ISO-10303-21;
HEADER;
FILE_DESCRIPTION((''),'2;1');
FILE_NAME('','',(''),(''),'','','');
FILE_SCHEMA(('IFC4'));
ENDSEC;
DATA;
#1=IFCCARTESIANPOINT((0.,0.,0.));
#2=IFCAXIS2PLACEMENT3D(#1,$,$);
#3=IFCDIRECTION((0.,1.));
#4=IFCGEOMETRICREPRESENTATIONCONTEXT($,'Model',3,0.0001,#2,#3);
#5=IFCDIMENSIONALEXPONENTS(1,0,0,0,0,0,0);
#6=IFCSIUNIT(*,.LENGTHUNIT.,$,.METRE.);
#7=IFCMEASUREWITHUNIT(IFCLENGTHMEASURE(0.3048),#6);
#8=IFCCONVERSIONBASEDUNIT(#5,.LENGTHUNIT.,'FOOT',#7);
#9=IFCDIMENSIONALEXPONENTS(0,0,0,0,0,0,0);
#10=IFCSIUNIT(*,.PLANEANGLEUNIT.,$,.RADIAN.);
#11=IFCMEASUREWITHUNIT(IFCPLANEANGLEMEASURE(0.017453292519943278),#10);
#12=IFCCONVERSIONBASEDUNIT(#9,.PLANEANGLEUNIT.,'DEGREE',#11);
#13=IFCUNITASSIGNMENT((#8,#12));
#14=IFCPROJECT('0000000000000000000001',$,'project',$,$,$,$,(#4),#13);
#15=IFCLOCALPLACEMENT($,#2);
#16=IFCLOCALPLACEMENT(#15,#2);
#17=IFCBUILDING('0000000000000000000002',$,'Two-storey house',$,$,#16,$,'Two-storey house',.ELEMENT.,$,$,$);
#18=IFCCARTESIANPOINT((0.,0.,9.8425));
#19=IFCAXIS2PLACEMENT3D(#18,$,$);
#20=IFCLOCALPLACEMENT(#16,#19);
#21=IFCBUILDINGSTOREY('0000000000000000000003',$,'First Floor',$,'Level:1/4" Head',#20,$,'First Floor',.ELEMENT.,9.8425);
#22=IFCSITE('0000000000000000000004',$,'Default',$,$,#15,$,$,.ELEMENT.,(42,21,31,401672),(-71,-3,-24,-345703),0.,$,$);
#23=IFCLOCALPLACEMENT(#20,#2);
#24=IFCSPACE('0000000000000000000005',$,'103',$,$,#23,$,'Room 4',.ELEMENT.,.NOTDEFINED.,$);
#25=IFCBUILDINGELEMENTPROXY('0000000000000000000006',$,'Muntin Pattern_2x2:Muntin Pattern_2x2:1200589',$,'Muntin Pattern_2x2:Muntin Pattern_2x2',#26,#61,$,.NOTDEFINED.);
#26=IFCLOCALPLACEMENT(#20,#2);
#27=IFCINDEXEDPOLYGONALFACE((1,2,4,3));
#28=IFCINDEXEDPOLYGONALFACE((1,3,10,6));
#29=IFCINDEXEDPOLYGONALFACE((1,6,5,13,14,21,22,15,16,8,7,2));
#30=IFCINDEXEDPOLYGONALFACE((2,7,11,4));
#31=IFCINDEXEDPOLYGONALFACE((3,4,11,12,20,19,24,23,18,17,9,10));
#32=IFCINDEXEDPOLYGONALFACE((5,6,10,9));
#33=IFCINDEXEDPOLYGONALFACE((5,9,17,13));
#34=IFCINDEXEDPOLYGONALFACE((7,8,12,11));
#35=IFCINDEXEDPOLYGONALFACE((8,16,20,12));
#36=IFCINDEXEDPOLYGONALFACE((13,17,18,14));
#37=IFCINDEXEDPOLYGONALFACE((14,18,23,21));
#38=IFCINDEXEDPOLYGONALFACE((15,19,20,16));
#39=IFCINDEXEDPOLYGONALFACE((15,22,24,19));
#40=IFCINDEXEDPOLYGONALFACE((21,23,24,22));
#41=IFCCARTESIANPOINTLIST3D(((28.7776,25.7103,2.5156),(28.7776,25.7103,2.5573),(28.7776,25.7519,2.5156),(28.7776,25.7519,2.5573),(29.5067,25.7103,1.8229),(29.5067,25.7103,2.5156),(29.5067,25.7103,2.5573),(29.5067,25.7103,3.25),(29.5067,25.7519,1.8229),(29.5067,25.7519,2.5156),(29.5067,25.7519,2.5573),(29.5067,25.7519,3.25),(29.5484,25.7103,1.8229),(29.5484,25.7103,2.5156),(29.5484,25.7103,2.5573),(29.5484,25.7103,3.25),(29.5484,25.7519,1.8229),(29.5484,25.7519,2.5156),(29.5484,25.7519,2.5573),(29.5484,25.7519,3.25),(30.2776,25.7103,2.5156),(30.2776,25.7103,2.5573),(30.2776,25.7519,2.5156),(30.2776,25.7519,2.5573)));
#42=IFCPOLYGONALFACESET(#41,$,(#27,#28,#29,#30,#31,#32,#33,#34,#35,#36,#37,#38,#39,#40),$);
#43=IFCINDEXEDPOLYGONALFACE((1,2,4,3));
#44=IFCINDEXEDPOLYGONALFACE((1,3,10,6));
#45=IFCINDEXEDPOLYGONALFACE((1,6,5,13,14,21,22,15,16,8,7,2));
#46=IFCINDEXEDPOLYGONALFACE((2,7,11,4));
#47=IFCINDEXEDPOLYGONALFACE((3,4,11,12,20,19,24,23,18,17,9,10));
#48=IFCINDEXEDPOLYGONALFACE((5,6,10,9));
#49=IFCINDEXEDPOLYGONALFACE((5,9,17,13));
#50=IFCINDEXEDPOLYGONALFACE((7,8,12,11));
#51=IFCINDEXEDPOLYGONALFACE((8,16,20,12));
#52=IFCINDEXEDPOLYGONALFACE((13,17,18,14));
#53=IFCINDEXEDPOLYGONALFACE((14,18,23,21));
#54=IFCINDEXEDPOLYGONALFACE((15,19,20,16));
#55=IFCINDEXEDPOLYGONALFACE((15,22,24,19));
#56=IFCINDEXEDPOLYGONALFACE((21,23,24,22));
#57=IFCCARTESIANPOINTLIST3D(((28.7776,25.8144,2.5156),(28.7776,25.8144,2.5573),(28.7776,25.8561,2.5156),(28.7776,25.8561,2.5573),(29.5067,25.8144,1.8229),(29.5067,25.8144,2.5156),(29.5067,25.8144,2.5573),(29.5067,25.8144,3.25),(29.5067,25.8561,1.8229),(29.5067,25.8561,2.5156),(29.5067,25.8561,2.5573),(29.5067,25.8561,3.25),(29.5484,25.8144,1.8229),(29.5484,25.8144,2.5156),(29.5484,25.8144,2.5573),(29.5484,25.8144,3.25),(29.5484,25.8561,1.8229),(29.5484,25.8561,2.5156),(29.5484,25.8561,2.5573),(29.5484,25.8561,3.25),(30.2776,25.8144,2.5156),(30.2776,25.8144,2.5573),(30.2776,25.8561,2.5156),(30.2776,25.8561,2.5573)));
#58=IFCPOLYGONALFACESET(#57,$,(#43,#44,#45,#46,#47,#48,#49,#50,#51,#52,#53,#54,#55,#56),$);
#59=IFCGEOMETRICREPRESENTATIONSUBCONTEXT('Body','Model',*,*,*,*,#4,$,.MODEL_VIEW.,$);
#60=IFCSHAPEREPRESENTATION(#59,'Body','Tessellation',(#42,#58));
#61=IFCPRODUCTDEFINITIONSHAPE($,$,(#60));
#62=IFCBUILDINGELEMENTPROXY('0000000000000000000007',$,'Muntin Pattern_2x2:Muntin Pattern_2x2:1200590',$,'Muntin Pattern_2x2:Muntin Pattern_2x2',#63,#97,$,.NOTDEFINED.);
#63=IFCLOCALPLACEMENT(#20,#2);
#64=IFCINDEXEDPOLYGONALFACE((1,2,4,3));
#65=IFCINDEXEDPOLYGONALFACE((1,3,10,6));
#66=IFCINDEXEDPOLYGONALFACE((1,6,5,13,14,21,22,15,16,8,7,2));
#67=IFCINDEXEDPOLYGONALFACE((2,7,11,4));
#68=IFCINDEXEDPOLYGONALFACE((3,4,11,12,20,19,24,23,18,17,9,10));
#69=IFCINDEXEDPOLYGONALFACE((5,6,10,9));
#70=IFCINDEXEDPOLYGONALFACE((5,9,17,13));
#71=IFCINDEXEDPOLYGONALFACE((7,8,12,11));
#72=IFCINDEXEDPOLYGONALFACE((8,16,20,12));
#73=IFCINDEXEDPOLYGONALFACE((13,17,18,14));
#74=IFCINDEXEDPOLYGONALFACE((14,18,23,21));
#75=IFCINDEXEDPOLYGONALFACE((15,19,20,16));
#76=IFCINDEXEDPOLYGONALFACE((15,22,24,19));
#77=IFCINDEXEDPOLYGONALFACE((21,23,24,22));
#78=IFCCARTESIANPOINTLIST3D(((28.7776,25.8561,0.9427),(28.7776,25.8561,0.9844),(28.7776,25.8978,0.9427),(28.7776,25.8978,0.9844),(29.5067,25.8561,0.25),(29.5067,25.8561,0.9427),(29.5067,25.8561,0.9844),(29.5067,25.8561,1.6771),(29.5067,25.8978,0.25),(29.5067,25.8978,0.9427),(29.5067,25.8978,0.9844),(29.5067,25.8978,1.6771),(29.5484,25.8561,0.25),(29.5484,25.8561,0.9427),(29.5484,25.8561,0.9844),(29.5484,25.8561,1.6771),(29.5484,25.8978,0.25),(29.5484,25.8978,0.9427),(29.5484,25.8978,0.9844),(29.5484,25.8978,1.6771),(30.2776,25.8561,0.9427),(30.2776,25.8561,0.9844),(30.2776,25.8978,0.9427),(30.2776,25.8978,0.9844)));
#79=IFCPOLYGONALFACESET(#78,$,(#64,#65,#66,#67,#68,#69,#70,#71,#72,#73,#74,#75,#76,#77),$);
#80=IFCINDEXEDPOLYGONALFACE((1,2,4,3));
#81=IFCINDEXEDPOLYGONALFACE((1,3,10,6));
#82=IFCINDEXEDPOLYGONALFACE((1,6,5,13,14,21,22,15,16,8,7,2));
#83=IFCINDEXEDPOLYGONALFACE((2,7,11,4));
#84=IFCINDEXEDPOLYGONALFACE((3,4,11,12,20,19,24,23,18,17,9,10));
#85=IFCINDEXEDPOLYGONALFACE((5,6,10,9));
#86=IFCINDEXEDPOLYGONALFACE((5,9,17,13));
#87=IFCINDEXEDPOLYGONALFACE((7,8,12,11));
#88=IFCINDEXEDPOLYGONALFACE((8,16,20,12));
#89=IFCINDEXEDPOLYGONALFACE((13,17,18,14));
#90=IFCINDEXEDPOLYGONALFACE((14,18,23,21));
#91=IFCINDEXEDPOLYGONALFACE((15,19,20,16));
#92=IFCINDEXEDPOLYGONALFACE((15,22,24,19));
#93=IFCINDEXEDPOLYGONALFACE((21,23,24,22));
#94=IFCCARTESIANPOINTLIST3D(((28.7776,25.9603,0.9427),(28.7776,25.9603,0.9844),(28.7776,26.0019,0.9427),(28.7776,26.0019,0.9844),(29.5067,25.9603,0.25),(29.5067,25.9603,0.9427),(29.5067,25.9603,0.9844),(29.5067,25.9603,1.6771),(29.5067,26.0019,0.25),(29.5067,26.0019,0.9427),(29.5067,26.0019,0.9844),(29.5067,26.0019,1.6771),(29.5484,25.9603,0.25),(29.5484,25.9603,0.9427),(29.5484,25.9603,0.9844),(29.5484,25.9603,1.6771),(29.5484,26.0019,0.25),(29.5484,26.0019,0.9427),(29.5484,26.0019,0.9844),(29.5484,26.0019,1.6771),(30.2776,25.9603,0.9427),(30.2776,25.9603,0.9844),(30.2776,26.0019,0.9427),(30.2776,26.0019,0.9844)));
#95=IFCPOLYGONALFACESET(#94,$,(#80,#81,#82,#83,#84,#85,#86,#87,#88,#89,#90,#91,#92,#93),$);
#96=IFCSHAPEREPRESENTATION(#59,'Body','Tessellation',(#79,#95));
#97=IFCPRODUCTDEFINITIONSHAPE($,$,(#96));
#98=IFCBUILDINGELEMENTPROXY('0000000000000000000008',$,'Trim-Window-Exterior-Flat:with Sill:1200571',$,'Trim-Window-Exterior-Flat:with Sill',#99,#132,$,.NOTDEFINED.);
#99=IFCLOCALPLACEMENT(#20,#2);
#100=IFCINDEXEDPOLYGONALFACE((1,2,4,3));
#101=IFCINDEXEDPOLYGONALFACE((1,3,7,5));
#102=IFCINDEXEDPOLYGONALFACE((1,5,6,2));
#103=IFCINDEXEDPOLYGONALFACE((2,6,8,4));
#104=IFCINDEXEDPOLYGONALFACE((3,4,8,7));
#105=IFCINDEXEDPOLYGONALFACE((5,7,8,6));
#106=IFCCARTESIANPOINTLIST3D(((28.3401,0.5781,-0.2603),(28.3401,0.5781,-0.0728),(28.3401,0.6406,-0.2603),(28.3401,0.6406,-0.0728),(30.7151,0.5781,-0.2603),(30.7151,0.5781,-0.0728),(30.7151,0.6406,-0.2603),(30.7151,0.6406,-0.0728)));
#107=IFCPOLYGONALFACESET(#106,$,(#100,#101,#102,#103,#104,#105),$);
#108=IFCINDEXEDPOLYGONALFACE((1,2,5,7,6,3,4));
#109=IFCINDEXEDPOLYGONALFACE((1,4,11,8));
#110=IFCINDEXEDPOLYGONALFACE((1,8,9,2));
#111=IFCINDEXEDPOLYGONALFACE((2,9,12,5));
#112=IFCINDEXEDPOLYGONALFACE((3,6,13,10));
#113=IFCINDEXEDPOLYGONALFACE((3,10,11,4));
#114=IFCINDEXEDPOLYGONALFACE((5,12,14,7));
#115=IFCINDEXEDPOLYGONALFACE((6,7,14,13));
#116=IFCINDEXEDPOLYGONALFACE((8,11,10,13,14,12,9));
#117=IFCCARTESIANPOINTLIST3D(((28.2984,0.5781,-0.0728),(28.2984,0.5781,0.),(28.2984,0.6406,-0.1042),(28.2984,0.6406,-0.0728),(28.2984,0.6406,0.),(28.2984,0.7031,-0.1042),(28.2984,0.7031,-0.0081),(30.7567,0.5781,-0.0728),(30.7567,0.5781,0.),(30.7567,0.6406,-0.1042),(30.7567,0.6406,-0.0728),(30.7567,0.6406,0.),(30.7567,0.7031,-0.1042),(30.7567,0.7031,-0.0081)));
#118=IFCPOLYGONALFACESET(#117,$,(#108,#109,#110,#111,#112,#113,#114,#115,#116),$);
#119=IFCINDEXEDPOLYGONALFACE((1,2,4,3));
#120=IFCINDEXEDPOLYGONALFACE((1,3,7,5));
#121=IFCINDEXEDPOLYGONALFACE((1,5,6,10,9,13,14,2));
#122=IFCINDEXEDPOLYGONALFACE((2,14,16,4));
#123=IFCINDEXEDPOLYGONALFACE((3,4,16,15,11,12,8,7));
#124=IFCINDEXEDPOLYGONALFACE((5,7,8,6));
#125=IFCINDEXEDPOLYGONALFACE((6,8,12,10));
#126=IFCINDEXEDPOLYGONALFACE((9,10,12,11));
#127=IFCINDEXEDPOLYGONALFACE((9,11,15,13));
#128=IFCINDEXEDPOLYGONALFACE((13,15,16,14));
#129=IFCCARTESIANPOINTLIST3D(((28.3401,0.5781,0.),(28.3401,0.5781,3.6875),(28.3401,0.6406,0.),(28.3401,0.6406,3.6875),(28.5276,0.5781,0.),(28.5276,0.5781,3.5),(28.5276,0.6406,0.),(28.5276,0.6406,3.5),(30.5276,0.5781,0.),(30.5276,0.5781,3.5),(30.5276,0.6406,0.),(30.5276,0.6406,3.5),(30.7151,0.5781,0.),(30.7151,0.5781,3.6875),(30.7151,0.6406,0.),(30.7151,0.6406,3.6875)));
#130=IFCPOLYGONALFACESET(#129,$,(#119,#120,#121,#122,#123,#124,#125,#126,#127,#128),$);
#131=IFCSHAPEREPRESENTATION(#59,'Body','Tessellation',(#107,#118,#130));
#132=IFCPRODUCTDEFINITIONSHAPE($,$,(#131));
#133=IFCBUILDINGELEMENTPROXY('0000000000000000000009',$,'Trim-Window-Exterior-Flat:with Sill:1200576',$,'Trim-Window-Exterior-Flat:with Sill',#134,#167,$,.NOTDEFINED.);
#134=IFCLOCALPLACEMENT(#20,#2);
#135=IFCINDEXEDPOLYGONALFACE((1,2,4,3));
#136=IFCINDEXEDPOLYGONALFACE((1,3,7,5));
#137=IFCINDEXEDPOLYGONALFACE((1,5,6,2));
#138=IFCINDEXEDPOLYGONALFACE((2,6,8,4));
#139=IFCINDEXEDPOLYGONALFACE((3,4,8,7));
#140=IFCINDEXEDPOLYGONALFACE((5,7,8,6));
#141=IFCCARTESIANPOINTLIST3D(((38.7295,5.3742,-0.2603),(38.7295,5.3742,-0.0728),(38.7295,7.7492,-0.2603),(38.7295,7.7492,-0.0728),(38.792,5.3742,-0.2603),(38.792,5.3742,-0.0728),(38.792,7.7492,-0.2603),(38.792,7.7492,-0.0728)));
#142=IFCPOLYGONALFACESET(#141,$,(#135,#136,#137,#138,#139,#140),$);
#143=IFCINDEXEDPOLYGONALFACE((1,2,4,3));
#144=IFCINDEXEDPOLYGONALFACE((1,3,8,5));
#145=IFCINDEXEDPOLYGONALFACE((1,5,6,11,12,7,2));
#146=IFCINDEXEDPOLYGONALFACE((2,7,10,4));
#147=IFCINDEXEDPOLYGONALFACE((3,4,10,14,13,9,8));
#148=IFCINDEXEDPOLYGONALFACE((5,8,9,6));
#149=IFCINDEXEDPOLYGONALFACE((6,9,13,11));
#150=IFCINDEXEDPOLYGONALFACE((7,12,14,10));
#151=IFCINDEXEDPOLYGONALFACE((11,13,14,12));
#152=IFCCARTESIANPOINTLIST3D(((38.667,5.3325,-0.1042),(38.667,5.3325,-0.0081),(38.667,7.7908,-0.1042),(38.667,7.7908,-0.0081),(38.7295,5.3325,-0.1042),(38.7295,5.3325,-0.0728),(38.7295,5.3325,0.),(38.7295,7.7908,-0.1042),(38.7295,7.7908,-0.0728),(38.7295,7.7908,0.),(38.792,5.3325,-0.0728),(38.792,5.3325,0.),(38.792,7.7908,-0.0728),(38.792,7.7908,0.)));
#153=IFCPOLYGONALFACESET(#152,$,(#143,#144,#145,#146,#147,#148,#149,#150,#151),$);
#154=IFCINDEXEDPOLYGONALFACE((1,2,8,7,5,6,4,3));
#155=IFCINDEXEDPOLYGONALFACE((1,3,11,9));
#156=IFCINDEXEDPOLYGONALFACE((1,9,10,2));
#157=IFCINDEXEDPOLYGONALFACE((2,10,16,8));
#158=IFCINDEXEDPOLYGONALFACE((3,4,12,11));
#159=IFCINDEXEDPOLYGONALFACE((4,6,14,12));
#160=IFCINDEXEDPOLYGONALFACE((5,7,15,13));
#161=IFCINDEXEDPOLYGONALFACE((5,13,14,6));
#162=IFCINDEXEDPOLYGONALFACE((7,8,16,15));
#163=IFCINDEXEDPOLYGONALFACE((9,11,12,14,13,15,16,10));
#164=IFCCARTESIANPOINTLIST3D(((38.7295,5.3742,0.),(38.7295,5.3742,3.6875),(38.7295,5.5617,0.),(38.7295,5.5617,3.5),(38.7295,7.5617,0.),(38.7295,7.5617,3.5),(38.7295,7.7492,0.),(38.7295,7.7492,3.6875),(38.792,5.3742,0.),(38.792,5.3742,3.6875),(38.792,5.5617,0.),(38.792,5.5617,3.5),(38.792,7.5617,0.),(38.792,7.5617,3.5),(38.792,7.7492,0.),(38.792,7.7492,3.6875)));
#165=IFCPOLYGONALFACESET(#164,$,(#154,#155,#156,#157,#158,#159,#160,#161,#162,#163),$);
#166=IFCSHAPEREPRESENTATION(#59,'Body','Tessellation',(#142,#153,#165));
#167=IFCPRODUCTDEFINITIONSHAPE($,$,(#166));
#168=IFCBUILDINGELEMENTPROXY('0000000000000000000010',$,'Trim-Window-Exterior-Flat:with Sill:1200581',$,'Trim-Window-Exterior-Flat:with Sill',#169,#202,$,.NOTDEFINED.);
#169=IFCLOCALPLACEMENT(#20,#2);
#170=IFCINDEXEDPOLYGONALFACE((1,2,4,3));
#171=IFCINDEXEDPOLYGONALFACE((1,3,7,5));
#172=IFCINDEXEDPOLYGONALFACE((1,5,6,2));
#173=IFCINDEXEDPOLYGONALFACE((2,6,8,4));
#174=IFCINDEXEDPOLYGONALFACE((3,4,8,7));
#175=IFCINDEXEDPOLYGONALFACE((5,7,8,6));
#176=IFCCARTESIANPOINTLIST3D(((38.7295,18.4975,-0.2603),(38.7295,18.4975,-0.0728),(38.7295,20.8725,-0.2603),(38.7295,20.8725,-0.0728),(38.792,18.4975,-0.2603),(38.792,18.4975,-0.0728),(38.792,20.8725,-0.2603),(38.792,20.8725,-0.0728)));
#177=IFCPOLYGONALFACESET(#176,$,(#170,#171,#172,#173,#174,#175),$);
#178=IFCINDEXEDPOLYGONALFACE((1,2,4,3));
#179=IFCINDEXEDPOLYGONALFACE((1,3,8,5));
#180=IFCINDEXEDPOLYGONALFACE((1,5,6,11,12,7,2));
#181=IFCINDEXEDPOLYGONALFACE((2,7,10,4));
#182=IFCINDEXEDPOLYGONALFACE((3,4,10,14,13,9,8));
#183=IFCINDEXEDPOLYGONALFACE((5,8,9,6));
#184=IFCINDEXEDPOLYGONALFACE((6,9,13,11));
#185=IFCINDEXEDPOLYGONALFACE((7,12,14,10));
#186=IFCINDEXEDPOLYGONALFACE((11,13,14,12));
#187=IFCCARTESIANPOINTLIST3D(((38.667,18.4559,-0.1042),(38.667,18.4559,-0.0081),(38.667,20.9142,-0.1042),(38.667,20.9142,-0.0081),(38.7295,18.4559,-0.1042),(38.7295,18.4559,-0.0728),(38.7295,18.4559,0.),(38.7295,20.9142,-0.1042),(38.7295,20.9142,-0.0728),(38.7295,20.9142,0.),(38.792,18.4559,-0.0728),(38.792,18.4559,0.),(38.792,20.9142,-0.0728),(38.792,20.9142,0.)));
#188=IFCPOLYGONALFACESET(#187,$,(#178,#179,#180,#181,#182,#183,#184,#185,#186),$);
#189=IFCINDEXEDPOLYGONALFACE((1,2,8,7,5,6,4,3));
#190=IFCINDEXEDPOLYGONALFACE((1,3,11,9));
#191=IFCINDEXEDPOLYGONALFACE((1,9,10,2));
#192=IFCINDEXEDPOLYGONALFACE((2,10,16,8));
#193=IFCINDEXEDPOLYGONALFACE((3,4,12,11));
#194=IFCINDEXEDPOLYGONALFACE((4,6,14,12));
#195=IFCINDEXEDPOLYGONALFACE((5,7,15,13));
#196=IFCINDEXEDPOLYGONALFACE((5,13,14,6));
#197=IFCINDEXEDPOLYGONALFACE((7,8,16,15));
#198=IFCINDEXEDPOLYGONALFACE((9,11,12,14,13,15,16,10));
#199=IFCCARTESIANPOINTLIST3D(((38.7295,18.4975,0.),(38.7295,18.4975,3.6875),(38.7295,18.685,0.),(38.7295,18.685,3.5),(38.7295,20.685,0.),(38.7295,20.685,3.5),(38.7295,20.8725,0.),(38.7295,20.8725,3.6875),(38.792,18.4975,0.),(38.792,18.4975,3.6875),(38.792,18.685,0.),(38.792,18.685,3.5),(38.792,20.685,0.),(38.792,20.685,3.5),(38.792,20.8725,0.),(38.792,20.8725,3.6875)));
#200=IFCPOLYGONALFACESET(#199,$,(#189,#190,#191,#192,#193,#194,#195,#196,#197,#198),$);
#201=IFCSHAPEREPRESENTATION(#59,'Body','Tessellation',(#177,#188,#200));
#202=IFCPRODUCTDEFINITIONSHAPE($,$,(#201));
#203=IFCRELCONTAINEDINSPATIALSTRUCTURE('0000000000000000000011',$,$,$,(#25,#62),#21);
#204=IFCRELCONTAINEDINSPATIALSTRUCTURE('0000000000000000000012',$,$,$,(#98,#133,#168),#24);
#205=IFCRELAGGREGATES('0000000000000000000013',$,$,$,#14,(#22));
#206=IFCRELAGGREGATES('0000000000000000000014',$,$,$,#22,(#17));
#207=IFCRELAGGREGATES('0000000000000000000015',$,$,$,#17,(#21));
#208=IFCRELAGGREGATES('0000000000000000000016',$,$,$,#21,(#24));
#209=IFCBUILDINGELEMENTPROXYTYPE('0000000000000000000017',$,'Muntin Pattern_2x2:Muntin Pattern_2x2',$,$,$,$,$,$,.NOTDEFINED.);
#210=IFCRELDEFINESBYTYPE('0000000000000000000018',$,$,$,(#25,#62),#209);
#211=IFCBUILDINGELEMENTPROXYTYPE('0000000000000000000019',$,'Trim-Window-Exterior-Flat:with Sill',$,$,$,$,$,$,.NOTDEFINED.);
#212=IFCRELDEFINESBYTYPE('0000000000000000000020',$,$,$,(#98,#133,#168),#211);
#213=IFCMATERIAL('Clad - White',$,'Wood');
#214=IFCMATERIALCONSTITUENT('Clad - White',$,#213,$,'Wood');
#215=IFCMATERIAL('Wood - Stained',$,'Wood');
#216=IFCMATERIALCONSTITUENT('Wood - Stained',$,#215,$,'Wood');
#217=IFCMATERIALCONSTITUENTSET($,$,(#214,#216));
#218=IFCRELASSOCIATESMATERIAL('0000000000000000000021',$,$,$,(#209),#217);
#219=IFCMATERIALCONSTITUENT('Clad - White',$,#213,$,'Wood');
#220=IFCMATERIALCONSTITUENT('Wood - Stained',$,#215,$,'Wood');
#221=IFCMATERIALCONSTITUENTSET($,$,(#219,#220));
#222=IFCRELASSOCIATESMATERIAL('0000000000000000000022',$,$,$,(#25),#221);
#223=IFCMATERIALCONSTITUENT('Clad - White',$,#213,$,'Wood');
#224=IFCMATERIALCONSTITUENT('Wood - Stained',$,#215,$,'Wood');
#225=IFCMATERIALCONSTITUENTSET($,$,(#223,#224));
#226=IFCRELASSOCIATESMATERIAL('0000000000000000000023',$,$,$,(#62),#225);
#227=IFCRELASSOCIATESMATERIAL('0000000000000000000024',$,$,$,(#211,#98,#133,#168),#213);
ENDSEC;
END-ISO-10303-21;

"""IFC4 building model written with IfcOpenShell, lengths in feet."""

from ifc_helpers import new_model, entity, si_unit, converted_unit, direction, frame, origin, place, context, subcontext, project, spatial, indexed_curve, outline, extrude, source, transform, mapped, material, constituent, constituent_set, type_object, type_shapes, element, save


model = new_model("IFC4")

# Units and contexts
model_context = context("Model", 3, precision=0.0001, world=origin(), true_north=direction((0.0, 1.0)))
body_context = subcontext(model_context, "Body", "Model", "MODEL_VIEW")
ifc_project = project(units=[converted_unit("LENGTHUNIT", "FOOT", entity("IfcLengthMeasure", 0.3048), si_unit("LENGTHUNIT", "METRE"), dimensions=[1, 0, 0, 0, 0, 0, 0]), converted_unit("PLANEANGLEUNIT", "DEGREE", entity("IfcPlaneAngleMeasure", 0.017453292519943278), si_unit("PLANEANGLEUNIT", "RADIAN"), dimensions=[0, 0, 0, 0, 0, 0, 0])], contexts=[model_context])

# Site, building, storey
site_placement = place(None, origin())
site = spatial("IfcSite", under=ifc_project, at=site_placement, Name="Default", CompositionType="ELEMENT", RefLatitude=(42, 21, 31, 401672), RefLongitude=(-71, -3, -24, -345703), RefElevation=0.0)
building_placement = place(site_placement, origin())
building = spatial("IfcBuilding", under=site, at=building_placement, Name="Two-storey house", LongName="Two-storey house", CompositionType="ELEMENT")
storey_placement = place(building_placement, frame((0.0, 0.0, 9.8425)))
storey = spatial("IfcBuildingStorey", under=building, at=storey_placement, Name="First Floor", ObjectType="Level:1/4\" Head", LongName="First Floor", CompositionType="ELEMENT", Elevation=9.8425)

# Shared definitions
ifc_material_1 = material(Name="Wood - Stained", Category="Wood")

# Building element proxies
ifc_material_2 = material(Name="Clad - White", Category="Wood")
ifc_constituent_1 = constituent(ifc_material_2, Name="Clad - White", Category="Wood")
ifc_constituent_2 = constituent(ifc_material_1, Name="Wood - Stained", Category="Wood")
ifc_constituent_set_1 = constituent_set(constituents=[ifc_constituent_1, ifc_constituent_2])
building_element_proxy_type_1 = type_object("IfcBuildingElementProxyType", Name="Muntin Pattern_2x2:Muntin Pattern_2x2", PredefinedType="NOTDEFINED", material=ifc_constituent_set_1)
shared_shape_1 = source(origin(), body_context, "Body", "SweptSolid", [
    extrude(outline(indexed_curve([(0.0208, -0.0208), (0.7135, -0.0208), (0.7135, 0.0208), (0.0208, 0.0208), (0.0208, 0.75), (-0.0208, 0.75), (-0.0208, 0.0208), (-0.7135, 0.0208), (-0.7135, -0.0208), (-0.0208, -0.0208), (-0.0208, -0.75), (0.0208, -0.75), (0.0208, -0.0208)], self_intersect=False)), frame((0.0, 0.0312, 0.7135), z_axis=(0.0, 1.0, 0.0), x_axis=(0.0, 0.0, 1.0)), (0.0, 0.0, 1.0), 0.0417),
    extrude(outline(indexed_curve([(0.0208, -0.0208), (0.7135, -0.0208), (0.7135, 0.0208), (0.0208, 0.0208), (0.0208, 0.75), (-0.0208, 0.75), (-0.0208, 0.0208), (-0.7135, 0.0208), (-0.7135, -0.0208), (-0.0208, -0.0208), (-0.0208, -0.75), (0.0208, -0.75), (0.0208, -0.0208)], self_intersect=False)), frame((0.0, -0.0729, 0.7135), z_axis=(0.0, 1.0, 0.0), x_axis=(0.0, 0.0, 1.0)), (0.0, 0.0, 1.0), 0.0417),
])
type_shapes(building_element_proxy_type_1, [shared_shape_1])
ifc_constituent_3 = constituent(ifc_material_2, Name="Clad - White", Category="Wood")
ifc_constituent_4 = constituent(ifc_material_1, Name="Wood - Stained", Category="Wood")
ifc_constituent_set_2 = constituent_set(constituents=[ifc_constituent_3, ifc_constituent_4])
proxy_1_placement = place(storey_placement, frame((29.5276, 25.7832, 1.8229), z_axis=(0.0, 0.0, 1.0), x_axis=(-1.0, 0.0, 0.0)))
element("IfcBuildingElementProxy", 1, at=proxy_1_placement, inside=storey, type_object=building_element_proxy_type_1, material=ifc_constituent_set_2, Name="Muntin Pattern_2x2:Muntin Pattern_2x2:1200589", ObjectType="Muntin Pattern_2x2:Muntin Pattern_2x2", PredefinedType="NOTDEFINED", context=body_context, shape_type="MappedRepresentation", body=[
    mapped(shared_shape_1, transform((0.0, 0.0, 0.0), scale=1.0)),
])
ifc_constituent_5 = constituent(ifc_material_2, Name="Clad - White", Category="Wood")
ifc_constituent_6 = constituent(ifc_material_1, Name="Wood - Stained", Category="Wood")
ifc_constituent_set_3 = constituent_set(constituents=[ifc_constituent_5, ifc_constituent_6])
proxy_2_placement = place(storey_placement, frame((29.5276, 25.929, 0.25), z_axis=(0.0, 0.0, 1.0), x_axis=(-1.0, 0.0, 0.0)))
element("IfcBuildingElementProxy", 2, at=proxy_2_placement, inside=storey, type_object=building_element_proxy_type_1, material=ifc_constituent_set_3, Name="Muntin Pattern_2x2:Muntin Pattern_2x2:1200590", ObjectType="Muntin Pattern_2x2:Muntin Pattern_2x2", PredefinedType="NOTDEFINED", context=body_context, shape_type="MappedRepresentation", body=[
    mapped(shared_shape_1, transform((0.0, 0.0, 0.0), scale=1.0)),
])

# Shared definitions
space_placement = place(storey_placement, origin())
space = spatial("IfcSpace", under=storey, at=space_placement, Name="103", LongName="Room 4", CompositionType="ELEMENT", PredefinedType="NOTDEFINED")

# Building element proxies
building_element_proxy_type_2 = type_object("IfcBuildingElementProxyType", Name="Trim-Window-Exterior-Flat:with Sill", PredefinedType="NOTDEFINED", material=ifc_material_2)
shared_shape_2 = source(origin(), body_context, "Body", "SweptSolid", [
    extrude(outline(indexed_curve([(-1.1875, -0.0938), (1.1875, -0.0938), (1.1875, 0.0938), (-1.1875, 0.0938), (-1.1875, -0.0938)], self_intersect=False)), frame((0.0, -3.6665, 0.0), z_axis=(0.0, 0.0, 1.0), x_axis=(-1.0, 0.0, 0.0)), (0.0, 0.0, 1.0), 0.0625),
    extrude(outline(indexed_curve([(-0.0625, -0.0525), (0.0, -0.0525), (0.0, -0.0211), (0.0625, -0.0211), (0.0625, 0.0517), (0.0, 0.0517), (-0.0625, 0.0436), (-0.0625, -0.0525)], self_intersect=False)), frame((-1.2292, -3.5517, 0.0625), z_axis=(1.0, 0.0, 0.0), x_axis=(0.0, 0.0, -1.0)), (0.0, 0.0, 1.0), 2.4583),
    extrude(outline(indexed_curve([(-1.8906, -1.1875), (1.7969, -1.1875), (1.7969, -1.0), (-1.7031, -1.0), (-1.7031, 1.0), (1.7969, 1.0), (1.7969, 1.1875), (-1.8906, 1.1875), (-1.8906, -1.1875)], self_intersect=False)), frame((0.0, -1.7031, 0.0), z_axis=(0.0, 0.0, 1.0), x_axis=(0.0, -1.0, 0.0)), (0.0, 0.0, 1.0), 0.0625),
])
type_shapes(building_element_proxy_type_2, [shared_shape_2])
for number, where, z_axis, x_axis, name in (
    (3, (29.5276, 0.5781, 3.5), (0.0, 1.0, 0.0), (-1.0, 0.0, 0.0), "Trim-Window-Exterior-Flat:with Sill:1200571"),
    (4, (38.792, 6.5617, 3.5), (-1.0, 0.0, 0.0), (0.0, -1.0, 0.0), "Trim-Window-Exterior-Flat:with Sill:1200576"),
    (5, (38.792, 19.685, 3.5), (-1.0, 0.0, 0.0), (0.0, -1.0, 0.0), "Trim-Window-Exterior-Flat:with Sill:1200581"),
):
    element("IfcBuildingElementProxy", number, at=place(space_placement, frame(where, z_axis=z_axis, x_axis=x_axis)), inside=space, type_object=building_element_proxy_type_2, material=ifc_material_2, Name=name, ObjectType="Trim-Window-Exterior-Flat:with Sill", PredefinedType="NOTDEFINED", context=body_context, shape_type="MappedRepresentation", body=[
        mapped(shared_shape_2, transform((0.0, 0.0, 0.0), scale=1.0)),
    ])

save(model, "model.ifc")
